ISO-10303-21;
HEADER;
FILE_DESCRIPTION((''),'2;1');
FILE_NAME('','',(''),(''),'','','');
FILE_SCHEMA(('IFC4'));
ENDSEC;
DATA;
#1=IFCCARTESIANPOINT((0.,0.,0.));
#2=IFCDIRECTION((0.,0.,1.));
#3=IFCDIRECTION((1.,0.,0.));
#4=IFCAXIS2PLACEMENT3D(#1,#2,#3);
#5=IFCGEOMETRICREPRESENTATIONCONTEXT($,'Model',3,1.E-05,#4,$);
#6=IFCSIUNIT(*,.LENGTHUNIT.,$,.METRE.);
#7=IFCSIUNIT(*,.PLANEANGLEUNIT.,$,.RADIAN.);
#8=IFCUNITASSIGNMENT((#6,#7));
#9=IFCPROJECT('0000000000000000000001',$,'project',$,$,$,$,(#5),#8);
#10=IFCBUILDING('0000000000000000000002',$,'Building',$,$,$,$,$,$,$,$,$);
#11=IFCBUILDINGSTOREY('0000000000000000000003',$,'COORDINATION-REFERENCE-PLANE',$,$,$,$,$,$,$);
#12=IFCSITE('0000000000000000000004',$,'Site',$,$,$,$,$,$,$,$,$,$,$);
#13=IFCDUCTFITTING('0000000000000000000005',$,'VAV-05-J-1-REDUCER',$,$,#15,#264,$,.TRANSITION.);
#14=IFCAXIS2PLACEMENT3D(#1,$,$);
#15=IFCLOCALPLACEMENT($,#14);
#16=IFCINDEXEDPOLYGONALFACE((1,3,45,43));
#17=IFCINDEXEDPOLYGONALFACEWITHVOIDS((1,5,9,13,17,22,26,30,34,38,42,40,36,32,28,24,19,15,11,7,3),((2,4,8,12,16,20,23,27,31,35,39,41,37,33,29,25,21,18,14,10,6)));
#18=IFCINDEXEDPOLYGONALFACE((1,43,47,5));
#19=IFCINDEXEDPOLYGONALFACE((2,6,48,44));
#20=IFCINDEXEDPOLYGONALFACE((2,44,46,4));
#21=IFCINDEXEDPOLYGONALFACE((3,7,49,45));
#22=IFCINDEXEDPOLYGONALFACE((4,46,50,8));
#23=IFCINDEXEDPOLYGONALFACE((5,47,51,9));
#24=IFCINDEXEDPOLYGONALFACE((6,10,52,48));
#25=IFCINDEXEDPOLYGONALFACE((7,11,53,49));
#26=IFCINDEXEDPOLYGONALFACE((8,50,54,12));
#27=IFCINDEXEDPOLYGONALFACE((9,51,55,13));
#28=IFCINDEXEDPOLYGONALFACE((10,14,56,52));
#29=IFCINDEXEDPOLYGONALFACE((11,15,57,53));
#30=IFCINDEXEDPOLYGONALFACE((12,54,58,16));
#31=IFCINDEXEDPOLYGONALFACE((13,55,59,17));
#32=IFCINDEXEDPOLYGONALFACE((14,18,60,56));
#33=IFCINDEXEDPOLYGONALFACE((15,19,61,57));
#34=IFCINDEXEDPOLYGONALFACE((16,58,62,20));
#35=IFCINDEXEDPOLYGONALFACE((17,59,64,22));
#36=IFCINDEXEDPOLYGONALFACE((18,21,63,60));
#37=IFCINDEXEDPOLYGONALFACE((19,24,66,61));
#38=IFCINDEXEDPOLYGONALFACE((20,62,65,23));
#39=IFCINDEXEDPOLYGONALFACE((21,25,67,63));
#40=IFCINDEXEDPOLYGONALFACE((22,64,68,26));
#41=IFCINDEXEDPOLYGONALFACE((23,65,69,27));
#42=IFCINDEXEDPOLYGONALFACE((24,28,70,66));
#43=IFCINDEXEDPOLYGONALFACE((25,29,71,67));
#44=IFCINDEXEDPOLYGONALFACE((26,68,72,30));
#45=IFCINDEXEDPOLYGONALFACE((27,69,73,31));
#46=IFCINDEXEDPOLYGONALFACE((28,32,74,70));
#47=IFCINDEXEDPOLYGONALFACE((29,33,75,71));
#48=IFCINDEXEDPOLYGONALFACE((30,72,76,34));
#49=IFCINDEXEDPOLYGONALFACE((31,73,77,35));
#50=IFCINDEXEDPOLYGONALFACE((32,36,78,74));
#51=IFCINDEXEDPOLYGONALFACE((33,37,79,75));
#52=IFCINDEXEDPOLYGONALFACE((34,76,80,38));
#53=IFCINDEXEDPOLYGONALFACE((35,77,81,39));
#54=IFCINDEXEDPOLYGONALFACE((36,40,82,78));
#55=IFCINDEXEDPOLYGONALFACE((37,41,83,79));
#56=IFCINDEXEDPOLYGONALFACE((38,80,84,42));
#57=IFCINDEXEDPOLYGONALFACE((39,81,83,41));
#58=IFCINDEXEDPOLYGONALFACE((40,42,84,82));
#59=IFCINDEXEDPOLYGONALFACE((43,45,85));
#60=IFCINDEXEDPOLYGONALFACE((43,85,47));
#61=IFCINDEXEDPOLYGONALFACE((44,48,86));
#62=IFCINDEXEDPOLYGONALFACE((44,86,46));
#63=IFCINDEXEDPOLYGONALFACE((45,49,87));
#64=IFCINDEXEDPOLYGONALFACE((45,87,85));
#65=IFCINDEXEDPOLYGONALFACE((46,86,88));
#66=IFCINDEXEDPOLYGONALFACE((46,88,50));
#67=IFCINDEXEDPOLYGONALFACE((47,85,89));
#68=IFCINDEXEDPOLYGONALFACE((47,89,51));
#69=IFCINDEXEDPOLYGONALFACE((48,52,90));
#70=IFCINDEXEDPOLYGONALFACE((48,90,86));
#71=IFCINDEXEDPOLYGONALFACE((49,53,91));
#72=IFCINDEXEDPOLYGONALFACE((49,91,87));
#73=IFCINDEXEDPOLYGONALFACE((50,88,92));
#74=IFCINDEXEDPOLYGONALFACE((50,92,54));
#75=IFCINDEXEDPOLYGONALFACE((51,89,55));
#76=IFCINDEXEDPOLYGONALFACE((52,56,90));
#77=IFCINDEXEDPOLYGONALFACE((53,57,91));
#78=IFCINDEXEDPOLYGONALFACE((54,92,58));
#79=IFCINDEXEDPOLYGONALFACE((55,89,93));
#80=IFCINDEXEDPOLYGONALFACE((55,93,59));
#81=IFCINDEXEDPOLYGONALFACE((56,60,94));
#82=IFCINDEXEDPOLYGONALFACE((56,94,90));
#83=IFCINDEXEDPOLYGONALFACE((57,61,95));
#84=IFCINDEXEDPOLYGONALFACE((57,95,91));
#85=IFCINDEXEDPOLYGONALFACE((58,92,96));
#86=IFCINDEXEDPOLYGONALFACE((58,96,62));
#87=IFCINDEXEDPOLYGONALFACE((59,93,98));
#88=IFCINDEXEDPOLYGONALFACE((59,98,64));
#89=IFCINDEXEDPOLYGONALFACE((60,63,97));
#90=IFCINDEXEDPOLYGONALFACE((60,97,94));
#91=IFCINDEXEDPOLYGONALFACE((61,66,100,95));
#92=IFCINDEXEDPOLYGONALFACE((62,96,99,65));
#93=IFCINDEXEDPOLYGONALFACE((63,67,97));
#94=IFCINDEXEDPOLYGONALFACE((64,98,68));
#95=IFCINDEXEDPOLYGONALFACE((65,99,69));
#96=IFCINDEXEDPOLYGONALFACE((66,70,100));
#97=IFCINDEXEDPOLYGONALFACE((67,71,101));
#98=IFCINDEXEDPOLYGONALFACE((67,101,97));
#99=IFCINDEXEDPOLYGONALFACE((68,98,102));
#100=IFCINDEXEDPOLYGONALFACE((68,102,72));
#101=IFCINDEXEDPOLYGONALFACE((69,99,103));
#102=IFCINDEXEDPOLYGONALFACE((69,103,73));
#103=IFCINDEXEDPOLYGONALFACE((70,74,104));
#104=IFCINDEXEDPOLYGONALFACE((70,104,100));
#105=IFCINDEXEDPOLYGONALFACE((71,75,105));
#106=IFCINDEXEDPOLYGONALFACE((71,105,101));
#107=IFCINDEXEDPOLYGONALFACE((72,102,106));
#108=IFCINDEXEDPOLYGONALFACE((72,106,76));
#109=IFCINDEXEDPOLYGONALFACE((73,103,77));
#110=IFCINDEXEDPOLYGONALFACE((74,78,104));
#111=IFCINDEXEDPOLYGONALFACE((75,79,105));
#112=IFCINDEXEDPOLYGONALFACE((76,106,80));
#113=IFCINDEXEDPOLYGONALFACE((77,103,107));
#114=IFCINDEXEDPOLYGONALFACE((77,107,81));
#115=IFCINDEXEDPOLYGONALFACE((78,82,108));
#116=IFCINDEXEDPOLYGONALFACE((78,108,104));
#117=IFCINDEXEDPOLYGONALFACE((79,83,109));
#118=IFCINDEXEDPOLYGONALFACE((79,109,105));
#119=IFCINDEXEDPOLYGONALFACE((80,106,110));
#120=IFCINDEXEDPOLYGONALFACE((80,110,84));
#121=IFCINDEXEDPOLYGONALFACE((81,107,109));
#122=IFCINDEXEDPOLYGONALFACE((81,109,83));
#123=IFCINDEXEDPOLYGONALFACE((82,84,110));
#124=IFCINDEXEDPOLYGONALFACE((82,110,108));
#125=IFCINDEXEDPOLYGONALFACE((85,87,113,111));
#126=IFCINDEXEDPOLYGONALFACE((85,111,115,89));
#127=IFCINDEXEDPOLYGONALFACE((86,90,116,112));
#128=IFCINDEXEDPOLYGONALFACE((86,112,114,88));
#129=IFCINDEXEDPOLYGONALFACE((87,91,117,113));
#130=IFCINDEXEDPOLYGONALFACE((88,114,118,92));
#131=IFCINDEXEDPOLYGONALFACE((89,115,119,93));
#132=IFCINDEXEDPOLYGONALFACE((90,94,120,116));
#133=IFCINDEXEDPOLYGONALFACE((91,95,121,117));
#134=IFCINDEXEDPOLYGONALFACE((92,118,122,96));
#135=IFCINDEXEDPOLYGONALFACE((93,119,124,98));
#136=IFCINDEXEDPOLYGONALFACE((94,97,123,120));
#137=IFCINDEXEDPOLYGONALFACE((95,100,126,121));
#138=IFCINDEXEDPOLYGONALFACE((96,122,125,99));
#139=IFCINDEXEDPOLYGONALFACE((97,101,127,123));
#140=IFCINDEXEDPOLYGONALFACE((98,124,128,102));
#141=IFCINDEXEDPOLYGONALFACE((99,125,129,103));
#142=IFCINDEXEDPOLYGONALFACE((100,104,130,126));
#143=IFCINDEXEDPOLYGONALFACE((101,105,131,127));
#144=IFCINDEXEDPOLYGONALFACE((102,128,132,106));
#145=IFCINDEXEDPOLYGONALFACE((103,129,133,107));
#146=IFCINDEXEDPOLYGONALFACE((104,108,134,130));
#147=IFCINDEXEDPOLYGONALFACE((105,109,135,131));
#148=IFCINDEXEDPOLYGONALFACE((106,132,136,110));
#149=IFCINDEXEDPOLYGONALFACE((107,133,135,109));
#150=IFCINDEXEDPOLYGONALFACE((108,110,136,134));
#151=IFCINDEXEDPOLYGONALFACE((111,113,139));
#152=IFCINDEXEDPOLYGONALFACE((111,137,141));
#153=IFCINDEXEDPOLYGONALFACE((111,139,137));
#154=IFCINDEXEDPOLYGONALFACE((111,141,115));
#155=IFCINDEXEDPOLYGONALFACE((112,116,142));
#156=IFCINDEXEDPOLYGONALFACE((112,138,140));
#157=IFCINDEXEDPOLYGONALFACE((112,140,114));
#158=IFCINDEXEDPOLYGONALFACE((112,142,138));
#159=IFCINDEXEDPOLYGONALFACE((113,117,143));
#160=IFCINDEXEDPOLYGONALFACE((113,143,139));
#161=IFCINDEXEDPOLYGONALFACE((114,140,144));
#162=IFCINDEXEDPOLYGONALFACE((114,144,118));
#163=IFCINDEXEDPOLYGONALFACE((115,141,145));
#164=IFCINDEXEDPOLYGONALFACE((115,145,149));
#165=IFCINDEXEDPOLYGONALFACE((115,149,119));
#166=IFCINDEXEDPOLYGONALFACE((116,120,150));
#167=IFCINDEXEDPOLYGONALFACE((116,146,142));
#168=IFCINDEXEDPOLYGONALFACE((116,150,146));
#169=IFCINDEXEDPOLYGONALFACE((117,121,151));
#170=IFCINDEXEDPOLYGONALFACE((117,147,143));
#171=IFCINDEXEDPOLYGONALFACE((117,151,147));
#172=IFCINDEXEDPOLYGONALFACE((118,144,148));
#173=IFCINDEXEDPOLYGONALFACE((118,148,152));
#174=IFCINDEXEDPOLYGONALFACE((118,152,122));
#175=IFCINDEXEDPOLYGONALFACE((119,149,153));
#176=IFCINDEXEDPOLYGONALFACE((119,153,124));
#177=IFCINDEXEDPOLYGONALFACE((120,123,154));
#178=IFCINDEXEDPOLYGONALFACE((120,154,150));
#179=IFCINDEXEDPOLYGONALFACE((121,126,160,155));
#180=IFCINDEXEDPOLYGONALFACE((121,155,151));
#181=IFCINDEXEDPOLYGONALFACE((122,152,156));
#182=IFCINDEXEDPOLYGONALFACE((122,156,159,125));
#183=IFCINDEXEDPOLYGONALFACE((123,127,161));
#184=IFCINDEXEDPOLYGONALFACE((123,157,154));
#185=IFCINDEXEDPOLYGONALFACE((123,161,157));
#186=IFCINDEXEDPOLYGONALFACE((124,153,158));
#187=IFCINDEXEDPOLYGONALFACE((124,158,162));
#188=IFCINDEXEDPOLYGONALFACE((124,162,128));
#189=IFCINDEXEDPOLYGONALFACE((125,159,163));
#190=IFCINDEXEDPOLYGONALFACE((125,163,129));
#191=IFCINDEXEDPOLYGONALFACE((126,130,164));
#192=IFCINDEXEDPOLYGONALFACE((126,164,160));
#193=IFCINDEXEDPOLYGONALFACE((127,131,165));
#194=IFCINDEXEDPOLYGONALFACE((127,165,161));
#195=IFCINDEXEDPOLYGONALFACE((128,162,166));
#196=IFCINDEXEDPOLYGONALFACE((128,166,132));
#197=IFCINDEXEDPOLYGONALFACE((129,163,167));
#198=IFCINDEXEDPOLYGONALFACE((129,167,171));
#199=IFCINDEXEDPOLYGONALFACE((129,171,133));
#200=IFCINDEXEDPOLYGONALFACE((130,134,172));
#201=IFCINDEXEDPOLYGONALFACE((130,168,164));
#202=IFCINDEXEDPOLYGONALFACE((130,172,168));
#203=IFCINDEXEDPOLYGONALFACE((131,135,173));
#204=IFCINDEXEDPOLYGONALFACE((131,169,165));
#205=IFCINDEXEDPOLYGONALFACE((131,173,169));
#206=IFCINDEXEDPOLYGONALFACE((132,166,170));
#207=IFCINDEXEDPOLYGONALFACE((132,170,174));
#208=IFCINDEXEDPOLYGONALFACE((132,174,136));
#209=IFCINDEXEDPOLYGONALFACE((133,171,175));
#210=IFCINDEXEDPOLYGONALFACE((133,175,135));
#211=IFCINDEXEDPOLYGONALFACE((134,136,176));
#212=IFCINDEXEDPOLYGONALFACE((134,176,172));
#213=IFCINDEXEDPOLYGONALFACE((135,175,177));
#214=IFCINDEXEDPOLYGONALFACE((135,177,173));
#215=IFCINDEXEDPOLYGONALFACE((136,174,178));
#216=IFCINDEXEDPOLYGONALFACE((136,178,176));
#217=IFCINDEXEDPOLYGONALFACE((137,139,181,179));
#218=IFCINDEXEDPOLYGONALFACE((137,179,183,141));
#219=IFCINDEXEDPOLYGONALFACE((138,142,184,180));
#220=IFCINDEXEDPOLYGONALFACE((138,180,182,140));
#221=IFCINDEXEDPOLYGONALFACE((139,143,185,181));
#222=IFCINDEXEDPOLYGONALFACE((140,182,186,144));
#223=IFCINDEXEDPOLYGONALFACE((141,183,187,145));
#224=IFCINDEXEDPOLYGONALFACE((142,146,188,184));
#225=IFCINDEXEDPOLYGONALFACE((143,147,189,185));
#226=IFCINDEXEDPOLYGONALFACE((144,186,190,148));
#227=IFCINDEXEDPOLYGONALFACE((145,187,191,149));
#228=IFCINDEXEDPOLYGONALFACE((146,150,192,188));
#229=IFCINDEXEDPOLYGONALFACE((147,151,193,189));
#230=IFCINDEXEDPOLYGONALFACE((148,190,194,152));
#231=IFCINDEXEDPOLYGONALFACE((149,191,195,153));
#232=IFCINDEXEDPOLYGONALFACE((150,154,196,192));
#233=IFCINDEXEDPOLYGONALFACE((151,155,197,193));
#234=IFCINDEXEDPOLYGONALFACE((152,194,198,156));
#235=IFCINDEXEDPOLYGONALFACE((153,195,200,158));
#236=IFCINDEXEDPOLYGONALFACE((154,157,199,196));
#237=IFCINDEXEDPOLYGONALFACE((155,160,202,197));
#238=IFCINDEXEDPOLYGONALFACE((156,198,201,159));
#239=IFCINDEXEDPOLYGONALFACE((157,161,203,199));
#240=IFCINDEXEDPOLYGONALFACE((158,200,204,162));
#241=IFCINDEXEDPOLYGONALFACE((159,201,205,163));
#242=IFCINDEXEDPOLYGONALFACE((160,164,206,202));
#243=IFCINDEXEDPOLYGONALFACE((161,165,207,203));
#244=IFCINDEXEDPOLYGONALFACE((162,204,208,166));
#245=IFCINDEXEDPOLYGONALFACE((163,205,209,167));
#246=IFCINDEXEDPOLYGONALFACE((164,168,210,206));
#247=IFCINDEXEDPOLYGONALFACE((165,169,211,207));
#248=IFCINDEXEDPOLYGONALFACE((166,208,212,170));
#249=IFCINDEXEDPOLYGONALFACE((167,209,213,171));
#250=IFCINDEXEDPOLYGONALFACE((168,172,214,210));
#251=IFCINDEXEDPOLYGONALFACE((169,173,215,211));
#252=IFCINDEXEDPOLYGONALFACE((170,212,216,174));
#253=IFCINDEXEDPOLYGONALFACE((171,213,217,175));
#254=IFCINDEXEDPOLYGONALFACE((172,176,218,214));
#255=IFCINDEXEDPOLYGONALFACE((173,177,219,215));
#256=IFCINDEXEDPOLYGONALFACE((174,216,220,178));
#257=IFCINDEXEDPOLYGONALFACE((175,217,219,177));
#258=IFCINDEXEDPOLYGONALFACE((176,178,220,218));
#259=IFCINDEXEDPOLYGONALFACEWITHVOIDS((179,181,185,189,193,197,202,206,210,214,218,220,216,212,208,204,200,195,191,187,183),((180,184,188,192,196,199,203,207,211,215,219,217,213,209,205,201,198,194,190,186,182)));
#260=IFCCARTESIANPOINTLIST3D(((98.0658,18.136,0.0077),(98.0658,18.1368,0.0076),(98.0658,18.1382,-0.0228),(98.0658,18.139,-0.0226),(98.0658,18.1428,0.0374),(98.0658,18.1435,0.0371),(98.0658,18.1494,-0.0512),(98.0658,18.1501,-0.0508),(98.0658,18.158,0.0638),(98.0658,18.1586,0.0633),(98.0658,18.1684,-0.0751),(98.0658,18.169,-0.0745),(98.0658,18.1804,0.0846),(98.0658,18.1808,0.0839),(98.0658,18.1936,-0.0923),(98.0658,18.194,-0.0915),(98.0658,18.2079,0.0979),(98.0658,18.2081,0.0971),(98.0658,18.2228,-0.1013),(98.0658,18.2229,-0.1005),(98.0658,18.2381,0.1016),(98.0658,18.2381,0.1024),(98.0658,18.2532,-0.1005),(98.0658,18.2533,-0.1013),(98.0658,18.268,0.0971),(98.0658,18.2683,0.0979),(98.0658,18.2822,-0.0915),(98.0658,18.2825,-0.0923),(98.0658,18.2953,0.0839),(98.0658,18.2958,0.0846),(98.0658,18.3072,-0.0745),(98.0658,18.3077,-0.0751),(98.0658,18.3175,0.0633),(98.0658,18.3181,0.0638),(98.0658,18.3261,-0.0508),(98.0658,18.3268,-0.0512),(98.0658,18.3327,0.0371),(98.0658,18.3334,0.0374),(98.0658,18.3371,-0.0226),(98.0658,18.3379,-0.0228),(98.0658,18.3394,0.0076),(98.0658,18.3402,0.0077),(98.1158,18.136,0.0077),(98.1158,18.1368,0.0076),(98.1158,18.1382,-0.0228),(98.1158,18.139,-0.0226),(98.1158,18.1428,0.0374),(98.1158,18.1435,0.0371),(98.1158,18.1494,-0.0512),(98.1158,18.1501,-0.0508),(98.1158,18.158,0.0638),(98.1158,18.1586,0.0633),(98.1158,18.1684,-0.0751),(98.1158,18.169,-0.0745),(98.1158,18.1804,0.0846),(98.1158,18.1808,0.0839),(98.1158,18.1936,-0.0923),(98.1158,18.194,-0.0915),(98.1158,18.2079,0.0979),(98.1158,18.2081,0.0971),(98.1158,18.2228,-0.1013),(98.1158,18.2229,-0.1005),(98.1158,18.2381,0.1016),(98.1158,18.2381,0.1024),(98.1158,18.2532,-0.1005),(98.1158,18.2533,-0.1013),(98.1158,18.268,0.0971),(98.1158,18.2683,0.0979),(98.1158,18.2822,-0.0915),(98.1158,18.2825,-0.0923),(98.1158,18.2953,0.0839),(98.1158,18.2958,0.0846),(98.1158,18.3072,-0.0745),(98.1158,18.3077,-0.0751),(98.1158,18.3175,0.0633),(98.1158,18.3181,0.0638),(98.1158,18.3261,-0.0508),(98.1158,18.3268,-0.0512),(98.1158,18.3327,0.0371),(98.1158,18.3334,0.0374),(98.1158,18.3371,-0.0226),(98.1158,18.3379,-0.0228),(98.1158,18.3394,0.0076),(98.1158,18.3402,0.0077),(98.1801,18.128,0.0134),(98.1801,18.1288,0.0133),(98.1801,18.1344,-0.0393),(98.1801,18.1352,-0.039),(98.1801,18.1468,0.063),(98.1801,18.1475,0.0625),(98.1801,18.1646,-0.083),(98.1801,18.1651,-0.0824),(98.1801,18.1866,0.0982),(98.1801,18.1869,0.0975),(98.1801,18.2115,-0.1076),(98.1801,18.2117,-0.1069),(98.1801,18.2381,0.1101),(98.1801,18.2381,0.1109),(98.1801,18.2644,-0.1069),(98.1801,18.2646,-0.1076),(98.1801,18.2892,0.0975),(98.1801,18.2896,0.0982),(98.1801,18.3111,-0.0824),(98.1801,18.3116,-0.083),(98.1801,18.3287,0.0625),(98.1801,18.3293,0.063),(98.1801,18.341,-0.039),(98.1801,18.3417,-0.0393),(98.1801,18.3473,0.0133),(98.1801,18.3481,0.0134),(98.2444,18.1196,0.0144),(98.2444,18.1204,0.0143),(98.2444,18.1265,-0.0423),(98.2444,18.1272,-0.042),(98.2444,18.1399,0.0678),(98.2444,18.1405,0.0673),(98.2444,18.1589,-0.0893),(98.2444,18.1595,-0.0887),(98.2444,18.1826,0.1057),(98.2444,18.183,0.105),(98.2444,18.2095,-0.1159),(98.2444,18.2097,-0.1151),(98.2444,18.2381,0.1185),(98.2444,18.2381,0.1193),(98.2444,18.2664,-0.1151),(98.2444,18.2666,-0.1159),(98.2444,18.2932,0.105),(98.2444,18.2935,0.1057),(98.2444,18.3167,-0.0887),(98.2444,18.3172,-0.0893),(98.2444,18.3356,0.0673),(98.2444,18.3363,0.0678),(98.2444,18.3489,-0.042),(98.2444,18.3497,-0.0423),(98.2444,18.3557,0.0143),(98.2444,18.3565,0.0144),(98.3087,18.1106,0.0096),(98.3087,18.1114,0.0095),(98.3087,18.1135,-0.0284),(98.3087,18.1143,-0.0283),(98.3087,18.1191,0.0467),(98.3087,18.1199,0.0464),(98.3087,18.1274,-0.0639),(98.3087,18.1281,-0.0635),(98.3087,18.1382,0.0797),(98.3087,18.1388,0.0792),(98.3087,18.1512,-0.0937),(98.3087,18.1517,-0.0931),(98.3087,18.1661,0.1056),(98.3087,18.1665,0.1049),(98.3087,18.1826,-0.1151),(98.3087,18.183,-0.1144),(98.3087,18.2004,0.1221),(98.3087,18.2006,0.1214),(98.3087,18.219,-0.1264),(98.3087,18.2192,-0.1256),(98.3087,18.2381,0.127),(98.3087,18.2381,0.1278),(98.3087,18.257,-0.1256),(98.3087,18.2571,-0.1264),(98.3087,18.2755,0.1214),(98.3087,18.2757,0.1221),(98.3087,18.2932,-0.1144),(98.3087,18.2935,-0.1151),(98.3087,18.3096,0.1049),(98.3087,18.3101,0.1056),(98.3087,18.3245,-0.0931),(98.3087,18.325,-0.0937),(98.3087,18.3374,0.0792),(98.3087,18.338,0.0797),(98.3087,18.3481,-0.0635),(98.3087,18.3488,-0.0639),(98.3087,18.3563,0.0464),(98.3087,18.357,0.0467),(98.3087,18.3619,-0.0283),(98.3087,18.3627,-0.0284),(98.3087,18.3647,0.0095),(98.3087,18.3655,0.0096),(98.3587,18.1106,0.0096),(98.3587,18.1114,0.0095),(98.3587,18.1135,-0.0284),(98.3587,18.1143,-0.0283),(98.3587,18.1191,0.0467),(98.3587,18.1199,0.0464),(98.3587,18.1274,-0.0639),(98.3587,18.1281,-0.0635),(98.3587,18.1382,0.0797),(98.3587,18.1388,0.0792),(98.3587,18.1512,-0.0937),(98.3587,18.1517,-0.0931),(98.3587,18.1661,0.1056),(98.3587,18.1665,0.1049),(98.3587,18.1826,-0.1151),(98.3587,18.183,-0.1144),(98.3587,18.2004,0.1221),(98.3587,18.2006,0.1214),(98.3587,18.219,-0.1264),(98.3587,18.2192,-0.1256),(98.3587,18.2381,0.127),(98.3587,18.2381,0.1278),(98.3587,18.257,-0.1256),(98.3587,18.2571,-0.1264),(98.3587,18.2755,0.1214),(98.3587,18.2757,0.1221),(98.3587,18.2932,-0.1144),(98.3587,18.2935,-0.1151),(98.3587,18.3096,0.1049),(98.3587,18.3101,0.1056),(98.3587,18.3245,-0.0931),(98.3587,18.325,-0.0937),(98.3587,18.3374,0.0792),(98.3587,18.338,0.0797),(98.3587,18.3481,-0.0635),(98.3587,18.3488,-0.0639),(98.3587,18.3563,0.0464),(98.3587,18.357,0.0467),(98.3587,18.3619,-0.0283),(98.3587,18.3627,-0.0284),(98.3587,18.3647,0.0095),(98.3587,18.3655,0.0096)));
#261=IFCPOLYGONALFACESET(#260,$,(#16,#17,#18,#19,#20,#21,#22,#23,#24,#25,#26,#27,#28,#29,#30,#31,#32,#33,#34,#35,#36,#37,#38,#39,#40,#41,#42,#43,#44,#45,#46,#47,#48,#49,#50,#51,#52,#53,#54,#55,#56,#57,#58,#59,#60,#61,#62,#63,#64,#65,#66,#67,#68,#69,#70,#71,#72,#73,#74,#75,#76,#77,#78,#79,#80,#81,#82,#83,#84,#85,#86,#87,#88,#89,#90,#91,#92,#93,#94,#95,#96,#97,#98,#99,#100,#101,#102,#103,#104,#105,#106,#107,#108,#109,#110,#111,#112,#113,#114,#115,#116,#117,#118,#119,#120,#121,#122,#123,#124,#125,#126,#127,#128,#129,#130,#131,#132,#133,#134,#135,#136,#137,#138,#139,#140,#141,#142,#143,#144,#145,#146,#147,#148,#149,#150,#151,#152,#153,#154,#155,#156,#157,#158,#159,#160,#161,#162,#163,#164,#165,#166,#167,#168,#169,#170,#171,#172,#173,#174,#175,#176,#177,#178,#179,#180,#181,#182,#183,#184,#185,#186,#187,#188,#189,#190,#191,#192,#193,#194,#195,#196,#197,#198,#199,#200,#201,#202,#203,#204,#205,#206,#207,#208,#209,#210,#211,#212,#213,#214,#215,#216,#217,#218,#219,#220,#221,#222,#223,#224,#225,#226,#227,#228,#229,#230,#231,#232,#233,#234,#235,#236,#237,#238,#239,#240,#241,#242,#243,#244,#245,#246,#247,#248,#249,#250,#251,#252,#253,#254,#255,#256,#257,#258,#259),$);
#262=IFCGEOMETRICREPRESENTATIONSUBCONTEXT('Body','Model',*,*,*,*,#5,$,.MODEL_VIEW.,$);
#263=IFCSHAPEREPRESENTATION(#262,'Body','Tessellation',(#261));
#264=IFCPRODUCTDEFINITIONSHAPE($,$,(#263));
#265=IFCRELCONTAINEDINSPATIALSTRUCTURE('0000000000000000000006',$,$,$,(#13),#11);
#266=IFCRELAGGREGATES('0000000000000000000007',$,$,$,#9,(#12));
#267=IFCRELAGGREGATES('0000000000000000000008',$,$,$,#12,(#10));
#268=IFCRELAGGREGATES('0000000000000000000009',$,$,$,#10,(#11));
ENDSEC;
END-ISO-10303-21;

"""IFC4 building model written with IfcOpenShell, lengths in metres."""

from ifc_helpers import new_model, entity, si_unit, frame, origin_with_axes, place, context, subcontext, project, spatial, element, save


model = new_model("IFC4")

# Units and contexts
model_context = context("Model", 3, precision=1e-05, world=origin_with_axes())
body_context_1 = subcontext(model_context, "Body", "Model", "MODEL_VIEW")
ifc_project = project(units=[si_unit("LENGTHUNIT", "METRE"), si_unit("PLANEANGLEUNIT", "RADIAN")], contexts=[model_context])

# Site, building, storey
site = spatial("IfcSite", under=ifc_project, Name="Site")
building = spatial("IfcBuilding", under=site, Name="Building")
storey = spatial("IfcBuildingStorey", under=building, Name="COORDINATION-REFERENCE-PLANE")

# Duct fitting
for number, where, z_axis, x_axis, name in (
    (1, (98.3587, 18.2381, 0.0), (0.0, -1.0, 0.0), (0.0, 0.0, 1.0), "VAV-05-J-1-REDUCER"),
):
    element("IfcDuctFitting", number, at=place(None, frame(where, z_axis=z_axis, x_axis=x_axis)), inside=storey, Name=name, PredefinedType="TRANSITION", context=body_context_1, shape_type="SweptSolid", body=[
        entity("IfcRevolvedAreaSolid", entity("IfcArbitraryClosedProfileDef", "AREA", None, entity("IfcPolyline", [entity("IfcCartesianPoint", [0.1278, 0.0]), entity("IfcCartesianPoint", [0.1278, 0.05]), entity("IfcCartesianPoint", [0.1024, 0.2429]), entity("IfcCartesianPoint", [0.1024, 0.2929]), entity("IfcCartesianPoint", [0.1016, 0.2929]), entity("IfcCartesianPoint", [0.1016, 0.2429]), entity("IfcCartesianPoint", [0.127, 0.05]), entity("IfcCartesianPoint", [0.127, 0.0]), entity("IfcCartesianPoint", [0.1278, 0.0])])), entity("IfcAxis2Placement3D", entity("IfcCartesianPoint", [0.0, 0.0, 0.0])), entity("IfcAxis1Placement", entity("IfcCartesianPoint", [0.0, 0.0, 0.0]), entity("IfcDirection", [0.0, 1.0, 0.0])), 6.283185),
    ])

save(model, "model.ifc")
